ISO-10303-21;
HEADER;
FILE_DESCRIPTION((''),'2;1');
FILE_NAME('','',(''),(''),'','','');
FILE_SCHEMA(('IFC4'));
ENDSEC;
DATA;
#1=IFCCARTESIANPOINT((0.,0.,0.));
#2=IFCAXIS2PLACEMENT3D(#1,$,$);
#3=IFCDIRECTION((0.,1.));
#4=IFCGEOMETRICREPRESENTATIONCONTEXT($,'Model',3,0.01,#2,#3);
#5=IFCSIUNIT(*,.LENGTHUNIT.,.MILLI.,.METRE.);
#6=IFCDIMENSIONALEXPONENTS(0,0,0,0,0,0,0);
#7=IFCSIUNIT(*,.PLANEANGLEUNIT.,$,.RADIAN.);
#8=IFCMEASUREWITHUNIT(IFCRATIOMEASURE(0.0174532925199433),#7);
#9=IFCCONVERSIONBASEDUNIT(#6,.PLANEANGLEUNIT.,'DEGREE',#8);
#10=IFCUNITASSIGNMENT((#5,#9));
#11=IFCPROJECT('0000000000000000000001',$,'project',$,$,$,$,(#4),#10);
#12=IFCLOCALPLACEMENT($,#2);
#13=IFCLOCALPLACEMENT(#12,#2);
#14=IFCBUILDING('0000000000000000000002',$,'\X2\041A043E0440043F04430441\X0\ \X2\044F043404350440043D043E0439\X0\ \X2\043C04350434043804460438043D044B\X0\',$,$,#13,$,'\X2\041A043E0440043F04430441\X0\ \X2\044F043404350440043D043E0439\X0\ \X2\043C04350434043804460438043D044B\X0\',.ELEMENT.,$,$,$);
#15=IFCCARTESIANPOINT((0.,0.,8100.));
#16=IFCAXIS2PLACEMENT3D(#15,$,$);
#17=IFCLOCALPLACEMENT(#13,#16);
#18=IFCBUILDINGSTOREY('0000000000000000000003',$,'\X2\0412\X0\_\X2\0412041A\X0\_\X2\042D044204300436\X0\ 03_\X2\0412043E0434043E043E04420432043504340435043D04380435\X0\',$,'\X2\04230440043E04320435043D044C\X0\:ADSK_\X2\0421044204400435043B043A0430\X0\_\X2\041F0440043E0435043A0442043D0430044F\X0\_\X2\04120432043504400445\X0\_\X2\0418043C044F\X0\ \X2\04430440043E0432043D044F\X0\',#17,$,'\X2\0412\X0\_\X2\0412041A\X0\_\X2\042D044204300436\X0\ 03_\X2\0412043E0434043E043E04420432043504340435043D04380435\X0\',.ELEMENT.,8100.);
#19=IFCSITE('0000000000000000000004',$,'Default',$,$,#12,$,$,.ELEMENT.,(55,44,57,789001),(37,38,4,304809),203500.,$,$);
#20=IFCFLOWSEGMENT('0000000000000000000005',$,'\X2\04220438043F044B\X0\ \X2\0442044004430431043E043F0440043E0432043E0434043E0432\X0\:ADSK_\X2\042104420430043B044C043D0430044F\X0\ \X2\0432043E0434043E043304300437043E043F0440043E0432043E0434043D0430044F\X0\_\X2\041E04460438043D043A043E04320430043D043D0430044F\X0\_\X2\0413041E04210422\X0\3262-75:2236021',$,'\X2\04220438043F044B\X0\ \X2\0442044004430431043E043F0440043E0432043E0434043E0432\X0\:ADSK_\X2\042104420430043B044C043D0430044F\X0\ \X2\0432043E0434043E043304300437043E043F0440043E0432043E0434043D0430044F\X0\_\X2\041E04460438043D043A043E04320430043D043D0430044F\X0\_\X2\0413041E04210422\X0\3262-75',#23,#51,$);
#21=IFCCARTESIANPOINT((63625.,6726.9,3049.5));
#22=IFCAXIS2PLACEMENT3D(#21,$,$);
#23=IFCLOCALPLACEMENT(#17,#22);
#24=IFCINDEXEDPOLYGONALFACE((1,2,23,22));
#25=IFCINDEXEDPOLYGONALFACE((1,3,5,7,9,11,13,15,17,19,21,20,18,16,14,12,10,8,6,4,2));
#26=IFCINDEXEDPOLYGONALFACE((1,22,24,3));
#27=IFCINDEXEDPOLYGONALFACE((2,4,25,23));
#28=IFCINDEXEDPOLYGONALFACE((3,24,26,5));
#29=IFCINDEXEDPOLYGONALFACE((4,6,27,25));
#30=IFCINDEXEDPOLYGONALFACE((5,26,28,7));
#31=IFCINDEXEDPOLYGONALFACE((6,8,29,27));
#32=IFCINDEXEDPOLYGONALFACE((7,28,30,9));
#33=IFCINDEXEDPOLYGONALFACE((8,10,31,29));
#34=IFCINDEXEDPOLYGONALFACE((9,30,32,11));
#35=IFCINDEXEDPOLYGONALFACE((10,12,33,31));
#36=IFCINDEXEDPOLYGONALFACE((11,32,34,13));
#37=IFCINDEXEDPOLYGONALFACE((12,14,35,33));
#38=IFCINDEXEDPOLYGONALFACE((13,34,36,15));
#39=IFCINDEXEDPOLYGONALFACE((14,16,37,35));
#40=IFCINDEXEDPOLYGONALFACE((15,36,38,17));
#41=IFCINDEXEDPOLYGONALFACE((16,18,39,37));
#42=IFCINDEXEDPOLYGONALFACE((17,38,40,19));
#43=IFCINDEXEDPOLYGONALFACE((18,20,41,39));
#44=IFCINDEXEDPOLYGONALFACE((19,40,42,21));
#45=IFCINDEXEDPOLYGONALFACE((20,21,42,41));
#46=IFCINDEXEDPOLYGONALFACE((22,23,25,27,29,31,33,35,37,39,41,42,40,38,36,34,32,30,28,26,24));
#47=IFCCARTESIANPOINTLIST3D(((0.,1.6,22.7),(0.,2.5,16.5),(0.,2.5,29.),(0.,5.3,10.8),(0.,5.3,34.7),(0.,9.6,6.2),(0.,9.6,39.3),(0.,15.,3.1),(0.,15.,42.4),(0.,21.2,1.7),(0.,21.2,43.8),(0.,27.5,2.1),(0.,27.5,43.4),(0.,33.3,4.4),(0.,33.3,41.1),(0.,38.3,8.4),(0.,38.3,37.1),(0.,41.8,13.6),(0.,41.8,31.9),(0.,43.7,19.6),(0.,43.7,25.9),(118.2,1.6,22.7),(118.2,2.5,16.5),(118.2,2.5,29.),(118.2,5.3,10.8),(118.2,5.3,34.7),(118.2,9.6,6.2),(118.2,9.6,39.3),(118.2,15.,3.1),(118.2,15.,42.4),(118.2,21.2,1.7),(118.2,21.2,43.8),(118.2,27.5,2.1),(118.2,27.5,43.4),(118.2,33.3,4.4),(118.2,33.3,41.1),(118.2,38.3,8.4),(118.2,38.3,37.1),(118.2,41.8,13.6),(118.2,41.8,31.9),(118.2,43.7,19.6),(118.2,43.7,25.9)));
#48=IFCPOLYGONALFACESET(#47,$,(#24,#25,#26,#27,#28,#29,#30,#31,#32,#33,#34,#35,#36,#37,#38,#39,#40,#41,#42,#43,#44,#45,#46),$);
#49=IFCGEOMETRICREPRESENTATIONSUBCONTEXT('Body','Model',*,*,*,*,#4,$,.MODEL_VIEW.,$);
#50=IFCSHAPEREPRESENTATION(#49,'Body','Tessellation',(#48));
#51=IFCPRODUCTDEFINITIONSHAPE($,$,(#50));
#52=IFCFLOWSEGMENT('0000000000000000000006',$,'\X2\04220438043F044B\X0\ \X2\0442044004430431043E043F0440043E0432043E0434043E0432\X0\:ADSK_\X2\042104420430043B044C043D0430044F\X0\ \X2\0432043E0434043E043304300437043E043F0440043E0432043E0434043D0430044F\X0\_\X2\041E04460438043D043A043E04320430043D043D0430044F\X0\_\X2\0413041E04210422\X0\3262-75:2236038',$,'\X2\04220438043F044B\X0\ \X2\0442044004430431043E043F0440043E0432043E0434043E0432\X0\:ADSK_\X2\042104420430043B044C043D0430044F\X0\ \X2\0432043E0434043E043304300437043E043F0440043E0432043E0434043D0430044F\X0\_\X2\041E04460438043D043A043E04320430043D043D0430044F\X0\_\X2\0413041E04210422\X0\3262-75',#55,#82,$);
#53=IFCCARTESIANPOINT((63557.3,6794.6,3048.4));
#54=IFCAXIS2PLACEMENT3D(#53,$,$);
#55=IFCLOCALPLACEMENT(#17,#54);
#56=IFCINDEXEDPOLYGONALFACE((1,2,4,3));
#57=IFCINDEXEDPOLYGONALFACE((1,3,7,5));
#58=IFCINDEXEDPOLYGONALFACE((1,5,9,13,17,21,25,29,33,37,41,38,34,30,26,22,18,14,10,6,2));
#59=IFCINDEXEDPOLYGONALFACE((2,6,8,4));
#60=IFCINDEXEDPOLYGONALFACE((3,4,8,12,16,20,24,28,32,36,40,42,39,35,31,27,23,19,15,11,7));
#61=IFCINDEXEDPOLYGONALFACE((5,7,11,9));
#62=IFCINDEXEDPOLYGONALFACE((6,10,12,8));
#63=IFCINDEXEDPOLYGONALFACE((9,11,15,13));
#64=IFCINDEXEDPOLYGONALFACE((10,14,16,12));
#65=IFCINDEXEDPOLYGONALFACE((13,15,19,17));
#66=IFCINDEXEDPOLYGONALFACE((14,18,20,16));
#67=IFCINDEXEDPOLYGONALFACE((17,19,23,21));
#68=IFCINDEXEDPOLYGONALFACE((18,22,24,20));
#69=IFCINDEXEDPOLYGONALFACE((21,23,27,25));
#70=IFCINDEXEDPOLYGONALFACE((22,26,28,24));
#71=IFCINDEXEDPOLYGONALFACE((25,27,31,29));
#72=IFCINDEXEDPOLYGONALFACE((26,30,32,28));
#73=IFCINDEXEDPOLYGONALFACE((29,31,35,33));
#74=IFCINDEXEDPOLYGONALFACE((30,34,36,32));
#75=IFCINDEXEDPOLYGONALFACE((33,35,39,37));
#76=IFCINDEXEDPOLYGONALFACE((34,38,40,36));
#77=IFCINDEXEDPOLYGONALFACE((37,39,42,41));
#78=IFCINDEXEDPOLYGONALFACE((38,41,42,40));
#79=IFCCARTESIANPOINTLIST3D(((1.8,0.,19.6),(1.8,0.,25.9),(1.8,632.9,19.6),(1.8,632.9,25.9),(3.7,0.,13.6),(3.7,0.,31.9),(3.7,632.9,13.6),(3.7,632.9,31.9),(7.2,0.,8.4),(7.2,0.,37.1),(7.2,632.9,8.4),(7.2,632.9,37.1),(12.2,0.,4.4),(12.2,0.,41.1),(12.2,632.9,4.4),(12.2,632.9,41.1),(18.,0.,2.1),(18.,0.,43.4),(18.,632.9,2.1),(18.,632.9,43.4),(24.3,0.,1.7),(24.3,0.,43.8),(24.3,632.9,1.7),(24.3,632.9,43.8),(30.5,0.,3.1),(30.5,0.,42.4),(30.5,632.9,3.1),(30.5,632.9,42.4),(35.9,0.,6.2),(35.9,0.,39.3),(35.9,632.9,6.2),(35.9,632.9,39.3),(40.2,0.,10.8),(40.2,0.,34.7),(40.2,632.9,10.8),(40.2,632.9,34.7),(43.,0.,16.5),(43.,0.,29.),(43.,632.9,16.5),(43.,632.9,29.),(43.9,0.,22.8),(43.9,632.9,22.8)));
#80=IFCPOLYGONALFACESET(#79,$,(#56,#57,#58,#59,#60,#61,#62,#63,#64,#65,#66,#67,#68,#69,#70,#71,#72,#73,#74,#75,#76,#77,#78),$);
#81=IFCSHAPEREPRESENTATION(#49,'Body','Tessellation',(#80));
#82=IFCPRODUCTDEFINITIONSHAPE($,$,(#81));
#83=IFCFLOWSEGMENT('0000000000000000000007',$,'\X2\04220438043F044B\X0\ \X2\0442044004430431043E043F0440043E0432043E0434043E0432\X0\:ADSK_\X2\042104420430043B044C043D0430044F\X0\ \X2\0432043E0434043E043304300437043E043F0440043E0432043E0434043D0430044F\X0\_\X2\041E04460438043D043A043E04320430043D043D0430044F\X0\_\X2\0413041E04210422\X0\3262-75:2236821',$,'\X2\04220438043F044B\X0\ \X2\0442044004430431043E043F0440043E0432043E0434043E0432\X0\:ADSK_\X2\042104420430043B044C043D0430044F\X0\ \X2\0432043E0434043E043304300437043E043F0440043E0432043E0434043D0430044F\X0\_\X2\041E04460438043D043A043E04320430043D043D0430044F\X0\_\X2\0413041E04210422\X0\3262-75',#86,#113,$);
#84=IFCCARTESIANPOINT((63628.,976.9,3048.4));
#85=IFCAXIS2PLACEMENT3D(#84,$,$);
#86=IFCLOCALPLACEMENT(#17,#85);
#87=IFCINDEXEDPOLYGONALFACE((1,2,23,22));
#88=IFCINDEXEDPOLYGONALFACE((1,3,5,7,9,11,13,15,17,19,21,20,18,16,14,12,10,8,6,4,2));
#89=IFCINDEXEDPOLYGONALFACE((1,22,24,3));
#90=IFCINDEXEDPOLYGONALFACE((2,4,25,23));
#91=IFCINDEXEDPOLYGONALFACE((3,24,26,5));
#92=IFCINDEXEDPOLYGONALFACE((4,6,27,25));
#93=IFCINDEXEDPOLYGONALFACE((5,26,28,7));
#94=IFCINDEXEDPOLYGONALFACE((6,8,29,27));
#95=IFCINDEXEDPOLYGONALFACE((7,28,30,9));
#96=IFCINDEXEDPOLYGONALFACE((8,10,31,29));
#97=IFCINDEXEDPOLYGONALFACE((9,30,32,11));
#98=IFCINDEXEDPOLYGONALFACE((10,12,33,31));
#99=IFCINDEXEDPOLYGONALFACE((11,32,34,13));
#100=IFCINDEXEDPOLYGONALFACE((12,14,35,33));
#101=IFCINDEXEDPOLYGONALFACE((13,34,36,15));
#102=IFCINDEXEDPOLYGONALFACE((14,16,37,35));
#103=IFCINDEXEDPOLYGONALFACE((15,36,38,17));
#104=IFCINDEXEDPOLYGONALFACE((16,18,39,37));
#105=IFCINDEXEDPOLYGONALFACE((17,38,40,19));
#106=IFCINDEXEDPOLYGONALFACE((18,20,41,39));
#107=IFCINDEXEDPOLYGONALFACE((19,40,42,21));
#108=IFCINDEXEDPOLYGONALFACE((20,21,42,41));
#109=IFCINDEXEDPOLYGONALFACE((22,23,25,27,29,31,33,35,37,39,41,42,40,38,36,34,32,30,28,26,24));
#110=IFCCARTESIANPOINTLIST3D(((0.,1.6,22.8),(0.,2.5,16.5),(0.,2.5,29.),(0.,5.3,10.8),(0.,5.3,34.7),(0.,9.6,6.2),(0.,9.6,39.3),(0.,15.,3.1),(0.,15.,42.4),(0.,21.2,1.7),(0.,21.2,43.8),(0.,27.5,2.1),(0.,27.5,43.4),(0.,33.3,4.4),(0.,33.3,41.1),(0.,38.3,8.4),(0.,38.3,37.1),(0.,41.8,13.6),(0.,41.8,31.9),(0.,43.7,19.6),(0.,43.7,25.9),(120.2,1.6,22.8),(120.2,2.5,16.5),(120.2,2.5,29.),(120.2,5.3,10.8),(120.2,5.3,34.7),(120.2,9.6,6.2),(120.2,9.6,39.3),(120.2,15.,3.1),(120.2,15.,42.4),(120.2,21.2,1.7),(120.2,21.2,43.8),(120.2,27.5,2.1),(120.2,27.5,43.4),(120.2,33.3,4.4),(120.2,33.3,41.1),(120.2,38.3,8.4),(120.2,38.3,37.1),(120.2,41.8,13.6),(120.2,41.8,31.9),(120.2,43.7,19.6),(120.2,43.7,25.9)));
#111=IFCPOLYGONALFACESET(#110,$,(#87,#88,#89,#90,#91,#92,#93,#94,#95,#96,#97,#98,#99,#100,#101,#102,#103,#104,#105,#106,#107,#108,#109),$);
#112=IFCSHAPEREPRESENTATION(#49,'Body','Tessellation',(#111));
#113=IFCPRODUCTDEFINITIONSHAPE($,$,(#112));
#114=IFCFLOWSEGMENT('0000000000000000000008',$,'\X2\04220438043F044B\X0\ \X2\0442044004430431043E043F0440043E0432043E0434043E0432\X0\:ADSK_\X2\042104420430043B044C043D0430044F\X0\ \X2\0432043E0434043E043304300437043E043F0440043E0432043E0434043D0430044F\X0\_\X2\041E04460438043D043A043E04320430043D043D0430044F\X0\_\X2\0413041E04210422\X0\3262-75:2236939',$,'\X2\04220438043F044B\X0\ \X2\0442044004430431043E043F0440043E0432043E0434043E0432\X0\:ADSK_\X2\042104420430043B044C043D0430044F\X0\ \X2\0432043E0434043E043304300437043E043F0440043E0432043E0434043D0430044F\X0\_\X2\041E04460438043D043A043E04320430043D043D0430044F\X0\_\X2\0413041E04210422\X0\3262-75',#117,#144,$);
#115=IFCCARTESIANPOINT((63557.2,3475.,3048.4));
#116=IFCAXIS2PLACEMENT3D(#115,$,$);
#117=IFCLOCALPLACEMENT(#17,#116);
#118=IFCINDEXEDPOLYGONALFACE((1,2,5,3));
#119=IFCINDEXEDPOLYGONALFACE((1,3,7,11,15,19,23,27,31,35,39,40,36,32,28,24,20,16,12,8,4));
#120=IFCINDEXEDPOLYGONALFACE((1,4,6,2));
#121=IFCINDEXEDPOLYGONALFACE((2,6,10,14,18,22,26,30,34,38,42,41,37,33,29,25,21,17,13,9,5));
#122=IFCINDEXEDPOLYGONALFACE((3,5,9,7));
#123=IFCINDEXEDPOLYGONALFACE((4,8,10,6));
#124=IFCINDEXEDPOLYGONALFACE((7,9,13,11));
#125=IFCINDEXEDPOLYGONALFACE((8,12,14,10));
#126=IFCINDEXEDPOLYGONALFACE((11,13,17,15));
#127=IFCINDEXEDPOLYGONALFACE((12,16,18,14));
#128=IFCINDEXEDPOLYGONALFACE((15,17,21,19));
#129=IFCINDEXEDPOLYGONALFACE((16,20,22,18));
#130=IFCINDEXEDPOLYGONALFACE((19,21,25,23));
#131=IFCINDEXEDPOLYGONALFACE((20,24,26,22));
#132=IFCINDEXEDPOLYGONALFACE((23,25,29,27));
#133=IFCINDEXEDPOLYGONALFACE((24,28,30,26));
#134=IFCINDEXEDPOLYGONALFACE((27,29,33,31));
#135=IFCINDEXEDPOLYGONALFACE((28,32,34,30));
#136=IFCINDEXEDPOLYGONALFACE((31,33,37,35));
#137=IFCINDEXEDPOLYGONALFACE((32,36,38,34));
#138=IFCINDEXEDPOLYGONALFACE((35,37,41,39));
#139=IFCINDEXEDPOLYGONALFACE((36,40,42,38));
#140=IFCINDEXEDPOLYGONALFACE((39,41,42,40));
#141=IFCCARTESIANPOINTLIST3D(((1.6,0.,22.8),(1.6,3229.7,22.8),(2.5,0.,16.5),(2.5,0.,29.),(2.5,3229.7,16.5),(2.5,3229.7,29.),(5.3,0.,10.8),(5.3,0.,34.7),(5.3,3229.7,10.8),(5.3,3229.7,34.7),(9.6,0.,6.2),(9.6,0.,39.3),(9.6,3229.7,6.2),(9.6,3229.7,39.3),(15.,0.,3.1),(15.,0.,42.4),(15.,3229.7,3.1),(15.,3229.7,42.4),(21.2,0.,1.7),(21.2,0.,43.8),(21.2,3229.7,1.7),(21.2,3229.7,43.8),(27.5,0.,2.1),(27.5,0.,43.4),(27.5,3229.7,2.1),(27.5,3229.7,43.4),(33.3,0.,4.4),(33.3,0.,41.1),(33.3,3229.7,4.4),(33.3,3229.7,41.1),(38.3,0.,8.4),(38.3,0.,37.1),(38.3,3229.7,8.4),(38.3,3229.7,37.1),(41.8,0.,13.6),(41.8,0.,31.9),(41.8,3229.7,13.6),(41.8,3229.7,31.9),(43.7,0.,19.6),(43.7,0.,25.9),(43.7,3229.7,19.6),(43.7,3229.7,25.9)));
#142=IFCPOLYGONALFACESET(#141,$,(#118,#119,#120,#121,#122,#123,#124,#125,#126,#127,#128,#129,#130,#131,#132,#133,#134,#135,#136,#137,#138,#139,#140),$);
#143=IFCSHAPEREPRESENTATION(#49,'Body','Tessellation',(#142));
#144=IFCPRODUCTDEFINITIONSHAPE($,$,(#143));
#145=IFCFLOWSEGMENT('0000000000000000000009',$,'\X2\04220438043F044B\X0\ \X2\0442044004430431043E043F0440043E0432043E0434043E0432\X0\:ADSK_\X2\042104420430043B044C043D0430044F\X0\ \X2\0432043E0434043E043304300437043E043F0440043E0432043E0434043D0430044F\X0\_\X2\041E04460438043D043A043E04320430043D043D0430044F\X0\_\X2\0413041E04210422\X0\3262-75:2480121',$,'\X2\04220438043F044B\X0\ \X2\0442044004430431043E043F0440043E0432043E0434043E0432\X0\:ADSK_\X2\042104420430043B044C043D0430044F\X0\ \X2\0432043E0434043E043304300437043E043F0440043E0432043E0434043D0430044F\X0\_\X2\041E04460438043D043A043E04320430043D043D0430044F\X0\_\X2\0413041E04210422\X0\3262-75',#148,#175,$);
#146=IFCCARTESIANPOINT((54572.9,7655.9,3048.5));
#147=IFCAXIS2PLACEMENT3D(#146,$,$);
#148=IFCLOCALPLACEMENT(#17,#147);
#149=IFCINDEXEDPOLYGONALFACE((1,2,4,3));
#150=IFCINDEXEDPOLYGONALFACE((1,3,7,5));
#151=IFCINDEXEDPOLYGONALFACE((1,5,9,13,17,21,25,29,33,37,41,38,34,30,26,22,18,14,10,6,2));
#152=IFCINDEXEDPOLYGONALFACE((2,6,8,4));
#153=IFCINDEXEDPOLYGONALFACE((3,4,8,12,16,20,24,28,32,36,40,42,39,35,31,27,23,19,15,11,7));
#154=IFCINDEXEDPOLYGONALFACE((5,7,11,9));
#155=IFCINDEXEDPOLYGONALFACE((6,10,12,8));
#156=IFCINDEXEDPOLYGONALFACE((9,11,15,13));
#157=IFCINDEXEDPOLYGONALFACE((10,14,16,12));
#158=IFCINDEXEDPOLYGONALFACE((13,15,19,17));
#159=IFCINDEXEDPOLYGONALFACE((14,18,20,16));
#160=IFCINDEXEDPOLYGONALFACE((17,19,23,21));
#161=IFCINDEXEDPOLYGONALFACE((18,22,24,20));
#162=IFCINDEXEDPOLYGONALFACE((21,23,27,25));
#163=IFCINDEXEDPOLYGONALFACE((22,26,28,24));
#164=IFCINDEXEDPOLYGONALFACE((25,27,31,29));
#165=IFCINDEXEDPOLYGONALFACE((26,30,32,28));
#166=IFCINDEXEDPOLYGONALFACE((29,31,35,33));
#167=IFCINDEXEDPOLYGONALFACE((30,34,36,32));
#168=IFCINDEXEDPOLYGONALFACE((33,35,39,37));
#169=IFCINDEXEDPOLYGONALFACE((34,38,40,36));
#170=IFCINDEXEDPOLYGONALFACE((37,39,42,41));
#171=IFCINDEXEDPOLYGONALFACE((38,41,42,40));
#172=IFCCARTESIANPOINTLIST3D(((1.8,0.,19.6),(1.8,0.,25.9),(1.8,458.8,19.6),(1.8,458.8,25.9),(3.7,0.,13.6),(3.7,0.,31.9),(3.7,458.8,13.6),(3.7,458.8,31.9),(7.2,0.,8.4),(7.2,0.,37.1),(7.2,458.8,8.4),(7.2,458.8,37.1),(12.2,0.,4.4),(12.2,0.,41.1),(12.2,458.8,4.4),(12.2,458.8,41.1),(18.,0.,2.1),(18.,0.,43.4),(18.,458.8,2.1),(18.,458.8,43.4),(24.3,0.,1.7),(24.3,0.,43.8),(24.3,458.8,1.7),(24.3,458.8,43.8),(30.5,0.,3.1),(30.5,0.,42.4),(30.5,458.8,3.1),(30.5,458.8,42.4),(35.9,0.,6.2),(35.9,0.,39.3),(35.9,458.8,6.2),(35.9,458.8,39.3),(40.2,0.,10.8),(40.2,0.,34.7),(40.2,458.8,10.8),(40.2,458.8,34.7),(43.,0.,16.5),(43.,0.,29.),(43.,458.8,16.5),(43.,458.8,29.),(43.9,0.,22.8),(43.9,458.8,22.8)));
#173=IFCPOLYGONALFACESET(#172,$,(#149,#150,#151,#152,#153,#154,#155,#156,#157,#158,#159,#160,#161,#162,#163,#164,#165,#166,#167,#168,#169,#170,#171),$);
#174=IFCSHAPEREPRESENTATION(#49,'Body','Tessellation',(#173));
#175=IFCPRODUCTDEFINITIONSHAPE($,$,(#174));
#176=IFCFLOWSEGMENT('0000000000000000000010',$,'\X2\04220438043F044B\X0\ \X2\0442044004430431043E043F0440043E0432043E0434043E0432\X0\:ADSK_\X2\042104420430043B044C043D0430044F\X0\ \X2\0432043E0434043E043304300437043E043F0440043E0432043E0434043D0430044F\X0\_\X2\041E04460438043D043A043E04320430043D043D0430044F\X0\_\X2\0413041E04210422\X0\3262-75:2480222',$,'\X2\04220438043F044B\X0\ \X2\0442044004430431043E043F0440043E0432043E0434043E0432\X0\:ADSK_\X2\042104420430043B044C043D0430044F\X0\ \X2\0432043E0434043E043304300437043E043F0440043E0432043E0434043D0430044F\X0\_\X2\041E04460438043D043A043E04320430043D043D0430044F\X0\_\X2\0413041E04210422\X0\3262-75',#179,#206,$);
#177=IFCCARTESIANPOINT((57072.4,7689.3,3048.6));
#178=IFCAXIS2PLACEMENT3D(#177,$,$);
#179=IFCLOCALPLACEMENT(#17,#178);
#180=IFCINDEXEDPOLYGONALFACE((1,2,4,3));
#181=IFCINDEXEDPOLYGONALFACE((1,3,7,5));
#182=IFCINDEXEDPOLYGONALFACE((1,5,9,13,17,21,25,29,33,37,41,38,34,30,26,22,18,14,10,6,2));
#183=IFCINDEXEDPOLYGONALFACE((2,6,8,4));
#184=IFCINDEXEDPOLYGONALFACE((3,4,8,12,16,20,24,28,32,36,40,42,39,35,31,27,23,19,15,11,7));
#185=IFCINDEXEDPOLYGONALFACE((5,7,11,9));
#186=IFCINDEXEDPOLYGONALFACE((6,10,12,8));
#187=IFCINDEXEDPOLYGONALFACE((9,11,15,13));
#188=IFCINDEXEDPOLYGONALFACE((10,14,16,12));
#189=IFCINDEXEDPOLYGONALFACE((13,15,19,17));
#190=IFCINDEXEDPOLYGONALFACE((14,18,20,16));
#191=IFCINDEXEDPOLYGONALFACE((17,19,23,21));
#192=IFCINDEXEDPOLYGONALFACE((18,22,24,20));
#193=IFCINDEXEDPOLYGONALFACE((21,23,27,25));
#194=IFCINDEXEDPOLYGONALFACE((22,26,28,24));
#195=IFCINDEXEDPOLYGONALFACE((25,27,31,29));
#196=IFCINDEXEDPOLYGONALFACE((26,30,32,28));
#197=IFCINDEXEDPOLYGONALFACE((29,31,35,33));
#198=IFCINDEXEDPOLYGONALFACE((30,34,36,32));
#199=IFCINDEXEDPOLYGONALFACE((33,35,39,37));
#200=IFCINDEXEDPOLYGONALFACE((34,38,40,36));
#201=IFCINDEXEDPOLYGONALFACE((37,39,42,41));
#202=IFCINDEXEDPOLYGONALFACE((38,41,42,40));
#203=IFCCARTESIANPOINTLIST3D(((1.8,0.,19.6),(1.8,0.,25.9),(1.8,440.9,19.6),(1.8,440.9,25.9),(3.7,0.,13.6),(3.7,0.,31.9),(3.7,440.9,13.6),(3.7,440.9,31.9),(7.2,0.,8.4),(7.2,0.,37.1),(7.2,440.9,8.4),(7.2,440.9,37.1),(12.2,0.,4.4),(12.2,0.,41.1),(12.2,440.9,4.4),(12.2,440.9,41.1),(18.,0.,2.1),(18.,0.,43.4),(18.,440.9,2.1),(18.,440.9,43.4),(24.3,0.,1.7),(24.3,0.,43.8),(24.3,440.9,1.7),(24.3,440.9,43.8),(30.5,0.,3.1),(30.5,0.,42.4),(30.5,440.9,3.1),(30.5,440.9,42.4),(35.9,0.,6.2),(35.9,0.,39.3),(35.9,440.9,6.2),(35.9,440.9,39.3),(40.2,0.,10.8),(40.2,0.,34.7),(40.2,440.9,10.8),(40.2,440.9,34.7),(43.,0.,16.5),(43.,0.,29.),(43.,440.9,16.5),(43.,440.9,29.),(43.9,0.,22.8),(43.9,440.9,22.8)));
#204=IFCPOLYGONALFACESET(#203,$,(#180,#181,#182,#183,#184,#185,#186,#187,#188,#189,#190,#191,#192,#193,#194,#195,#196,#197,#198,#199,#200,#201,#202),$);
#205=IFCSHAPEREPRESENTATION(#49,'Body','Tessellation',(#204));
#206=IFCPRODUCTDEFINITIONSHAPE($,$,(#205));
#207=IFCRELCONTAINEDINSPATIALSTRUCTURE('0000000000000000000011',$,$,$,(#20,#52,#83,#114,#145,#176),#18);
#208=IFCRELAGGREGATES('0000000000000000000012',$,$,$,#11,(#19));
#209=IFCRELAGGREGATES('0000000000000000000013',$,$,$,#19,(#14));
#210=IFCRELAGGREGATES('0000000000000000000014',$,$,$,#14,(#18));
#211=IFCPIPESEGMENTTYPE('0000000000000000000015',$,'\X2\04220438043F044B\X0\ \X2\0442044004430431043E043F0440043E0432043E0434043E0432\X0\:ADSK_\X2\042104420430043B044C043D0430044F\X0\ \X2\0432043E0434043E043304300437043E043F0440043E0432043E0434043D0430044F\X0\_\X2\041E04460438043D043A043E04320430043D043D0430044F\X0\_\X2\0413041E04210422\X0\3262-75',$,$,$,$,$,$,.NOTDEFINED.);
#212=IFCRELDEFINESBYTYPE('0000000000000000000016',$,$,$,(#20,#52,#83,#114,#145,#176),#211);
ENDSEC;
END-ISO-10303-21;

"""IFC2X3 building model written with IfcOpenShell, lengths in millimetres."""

from ifc_helpers import new_model, entity, si_unit, converted_unit, direction, frame, origin, origin_2d_with_axis, place, context, subcontext, project, spatial, circle, extrude, type_object, element, save


model = new_model("IFC2X3")

# Units and contexts
model_context = context("Model", 3, precision=0.01, world=origin(), true_north=direction((0.0, 1.0)))
body_context = subcontext(model_context, "Body", "Model", "MODEL_VIEW")
ifc_project = project(units=[si_unit("LENGTHUNIT", "METRE", prefix="MILLI"), converted_unit("PLANEANGLEUNIT", "DEGREE", entity("IfcRatioMeasure", 0.0174532925199433), si_unit("PLANEANGLEUNIT", "RADIAN"), dimensions=[0, 0, 0, 0, 0, 0, 0])], contexts=[model_context])

# Site, building, storey
site_placement = place(None, origin())
site = spatial("IfcSite", under=ifc_project, at=site_placement, Name="Default", CompositionType="ELEMENT", RefLatitude=(55, 44, 57, 789001), RefLongitude=(37, 38, 4, 304809), RefElevation=203500.0)
building_placement = place(site_placement, origin())
building = spatial("IfcBuilding", under=site, at=building_placement, Name="Корпус ядерной медицины", LongName="Корпус ядерной медицины", CompositionType="ELEMENT")
storey_placement = place(building_placement, frame((0.0, 0.0, 8100.0)))
storey = spatial("IfcBuildingStorey", under=building, at=storey_placement, Name="В_ВК_Этаж 03_Водоотведение", ObjectType="Уровень:ADSK_Стрелка_Проектная_Вверх_Имя уровня", LongName="В_ВК_Этаж 03_Водоотведение", CompositionType="ELEMENT", Elevation=8100.0)

# Flow segments
pipe_segment_type_1 = type_object("IfcPipeSegmentType", Name="Типы трубопроводов:ADSK_Стальная водогазопроводная_Оцинкованная_ГОСТ3262-75", PredefinedType="NOTDEFINED")
flow_segment_1_placement = place(storey_placement, frame((63625.0, 6726.9, 3049.5)))
element("IfcFlowSegment", 1, at=flow_segment_1_placement, inside=storey, type_object=pipe_segment_type_1, Name="Типы трубопроводов:ADSK_Стальная водогазопроводная_Оцинкованная_ГОСТ3262-75:2236021", ObjectType="Типы трубопроводов:ADSK_Стальная водогазопроводная_Оцинкованная_ГОСТ3262-75", context=body_context, shape_type="SweptSolid", body=[
    extrude(circle(Radius=21.1, at=origin_2d_with_axis()), frame((0.0, 22.8, 22.8), z_axis=(1.0, 0.0, 0.0), x_axis=(0.0, -1.0, 0.0)), (0.0, 0.0, 1.0), 118.2),
])
flow_segment_2_placement = place(storey_placement, frame((63557.3, 6794.6, 3048.4)))
element("IfcFlowSegment", 2, at=flow_segment_2_placement, inside=storey, type_object=pipe_segment_type_1, Name="Типы трубопроводов:ADSK_Стальная водогазопроводная_Оцинкованная_ГОСТ3262-75:2236038", ObjectType="Типы трубопроводов:ADSK_Стальная водогазопроводная_Оцинкованная_ГОСТ3262-75", context=body_context, shape_type="SweptSolid", body=[
    extrude(circle(Radius=21.1, at=origin_2d_with_axis()), frame((22.8, 0.0, 22.8), z_axis=(0.0, 1.0, 0.0), x_axis=(1.0, 0.0, 0.0)), (0.0, 0.0, 1.0), 632.9),
])
flow_segment_3_placement = place(storey_placement, frame((63628.0, 976.9, 3048.4)))
element("IfcFlowSegment", 3, at=flow_segment_3_placement, inside=storey, type_object=pipe_segment_type_1, Name="Типы трубопроводов:ADSK_Стальная водогазопроводная_Оцинкованная_ГОСТ3262-75:2236821", ObjectType="Типы трубопроводов:ADSK_Стальная водогазопроводная_Оцинкованная_ГОСТ3262-75", context=body_context, shape_type="SweptSolid", body=[
    extrude(circle(Radius=21.1, at=origin_2d_with_axis()), frame((0.0, 22.8, 22.8), z_axis=(1.0, 0.0, 0.0), x_axis=(0.0, -1.0, 0.0)), (0.0, 0.0, 1.0), 120.2),
])
flow_segment_4_placement = place(storey_placement, frame((63557.2, 3475.0, 3048.4)))
element("IfcFlowSegment", 4, at=flow_segment_4_placement, inside=storey, type_object=pipe_segment_type_1, Name="Типы трубопроводов:ADSK_Стальная водогазопроводная_Оцинкованная_ГОСТ3262-75:2236939", ObjectType="Типы трубопроводов:ADSK_Стальная водогазопроводная_Оцинкованная_ГОСТ3262-75", context=body_context, shape_type="SweptSolid", body=[
    extrude(circle(Radius=21.1, at=origin_2d_with_axis()), frame((22.8, 0.0, 22.8), z_axis=(0.0, 1.0, 0.0), x_axis=(-1.0, 0.0, 0.0)), (0.0, 0.0, 1.0), 3229.7),
])
flow_segment_5_placement = place(storey_placement, frame((54572.9, 7655.9, 3048.5)))
element("IfcFlowSegment", 5, at=flow_segment_5_placement, inside=storey, type_object=pipe_segment_type_1, Name="Типы трубопроводов:ADSK_Стальная водогазопроводная_Оцинкованная_ГОСТ3262-75:2480121", ObjectType="Типы трубопроводов:ADSK_Стальная водогазопроводная_Оцинкованная_ГОСТ3262-75", context=body_context, shape_type="SweptSolid", body=[
    extrude(circle(Radius=21.1, at=origin_2d_with_axis()), frame((22.8, 0.0, 22.8), z_axis=(0.0, 1.0, 0.0), x_axis=(1.0, 0.0, 0.0)), (0.0, 0.0, 1.0), 458.8),
])
flow_segment_6_placement = place(storey_placement, frame((57072.4, 7689.3, 3048.6)))
element("IfcFlowSegment", 6, at=flow_segment_6_placement, inside=storey, type_object=pipe_segment_type_1, Name="Типы трубопроводов:ADSK_Стальная водогазопроводная_Оцинкованная_ГОСТ3262-75:2480222", ObjectType="Типы трубопроводов:ADSK_Стальная водогазопроводная_Оцинкованная_ГОСТ3262-75", context=body_context, shape_type="SweptSolid", body=[
    extrude(circle(Radius=21.1, at=origin_2d_with_axis()), frame((22.8, 0.0, 22.8), z_axis=(0.0, 1.0, 0.0), x_axis=(1.0, 0.0, 0.0)), (0.0, 0.0, 1.0), 440.9),
])

save(model, "model.ifc")
